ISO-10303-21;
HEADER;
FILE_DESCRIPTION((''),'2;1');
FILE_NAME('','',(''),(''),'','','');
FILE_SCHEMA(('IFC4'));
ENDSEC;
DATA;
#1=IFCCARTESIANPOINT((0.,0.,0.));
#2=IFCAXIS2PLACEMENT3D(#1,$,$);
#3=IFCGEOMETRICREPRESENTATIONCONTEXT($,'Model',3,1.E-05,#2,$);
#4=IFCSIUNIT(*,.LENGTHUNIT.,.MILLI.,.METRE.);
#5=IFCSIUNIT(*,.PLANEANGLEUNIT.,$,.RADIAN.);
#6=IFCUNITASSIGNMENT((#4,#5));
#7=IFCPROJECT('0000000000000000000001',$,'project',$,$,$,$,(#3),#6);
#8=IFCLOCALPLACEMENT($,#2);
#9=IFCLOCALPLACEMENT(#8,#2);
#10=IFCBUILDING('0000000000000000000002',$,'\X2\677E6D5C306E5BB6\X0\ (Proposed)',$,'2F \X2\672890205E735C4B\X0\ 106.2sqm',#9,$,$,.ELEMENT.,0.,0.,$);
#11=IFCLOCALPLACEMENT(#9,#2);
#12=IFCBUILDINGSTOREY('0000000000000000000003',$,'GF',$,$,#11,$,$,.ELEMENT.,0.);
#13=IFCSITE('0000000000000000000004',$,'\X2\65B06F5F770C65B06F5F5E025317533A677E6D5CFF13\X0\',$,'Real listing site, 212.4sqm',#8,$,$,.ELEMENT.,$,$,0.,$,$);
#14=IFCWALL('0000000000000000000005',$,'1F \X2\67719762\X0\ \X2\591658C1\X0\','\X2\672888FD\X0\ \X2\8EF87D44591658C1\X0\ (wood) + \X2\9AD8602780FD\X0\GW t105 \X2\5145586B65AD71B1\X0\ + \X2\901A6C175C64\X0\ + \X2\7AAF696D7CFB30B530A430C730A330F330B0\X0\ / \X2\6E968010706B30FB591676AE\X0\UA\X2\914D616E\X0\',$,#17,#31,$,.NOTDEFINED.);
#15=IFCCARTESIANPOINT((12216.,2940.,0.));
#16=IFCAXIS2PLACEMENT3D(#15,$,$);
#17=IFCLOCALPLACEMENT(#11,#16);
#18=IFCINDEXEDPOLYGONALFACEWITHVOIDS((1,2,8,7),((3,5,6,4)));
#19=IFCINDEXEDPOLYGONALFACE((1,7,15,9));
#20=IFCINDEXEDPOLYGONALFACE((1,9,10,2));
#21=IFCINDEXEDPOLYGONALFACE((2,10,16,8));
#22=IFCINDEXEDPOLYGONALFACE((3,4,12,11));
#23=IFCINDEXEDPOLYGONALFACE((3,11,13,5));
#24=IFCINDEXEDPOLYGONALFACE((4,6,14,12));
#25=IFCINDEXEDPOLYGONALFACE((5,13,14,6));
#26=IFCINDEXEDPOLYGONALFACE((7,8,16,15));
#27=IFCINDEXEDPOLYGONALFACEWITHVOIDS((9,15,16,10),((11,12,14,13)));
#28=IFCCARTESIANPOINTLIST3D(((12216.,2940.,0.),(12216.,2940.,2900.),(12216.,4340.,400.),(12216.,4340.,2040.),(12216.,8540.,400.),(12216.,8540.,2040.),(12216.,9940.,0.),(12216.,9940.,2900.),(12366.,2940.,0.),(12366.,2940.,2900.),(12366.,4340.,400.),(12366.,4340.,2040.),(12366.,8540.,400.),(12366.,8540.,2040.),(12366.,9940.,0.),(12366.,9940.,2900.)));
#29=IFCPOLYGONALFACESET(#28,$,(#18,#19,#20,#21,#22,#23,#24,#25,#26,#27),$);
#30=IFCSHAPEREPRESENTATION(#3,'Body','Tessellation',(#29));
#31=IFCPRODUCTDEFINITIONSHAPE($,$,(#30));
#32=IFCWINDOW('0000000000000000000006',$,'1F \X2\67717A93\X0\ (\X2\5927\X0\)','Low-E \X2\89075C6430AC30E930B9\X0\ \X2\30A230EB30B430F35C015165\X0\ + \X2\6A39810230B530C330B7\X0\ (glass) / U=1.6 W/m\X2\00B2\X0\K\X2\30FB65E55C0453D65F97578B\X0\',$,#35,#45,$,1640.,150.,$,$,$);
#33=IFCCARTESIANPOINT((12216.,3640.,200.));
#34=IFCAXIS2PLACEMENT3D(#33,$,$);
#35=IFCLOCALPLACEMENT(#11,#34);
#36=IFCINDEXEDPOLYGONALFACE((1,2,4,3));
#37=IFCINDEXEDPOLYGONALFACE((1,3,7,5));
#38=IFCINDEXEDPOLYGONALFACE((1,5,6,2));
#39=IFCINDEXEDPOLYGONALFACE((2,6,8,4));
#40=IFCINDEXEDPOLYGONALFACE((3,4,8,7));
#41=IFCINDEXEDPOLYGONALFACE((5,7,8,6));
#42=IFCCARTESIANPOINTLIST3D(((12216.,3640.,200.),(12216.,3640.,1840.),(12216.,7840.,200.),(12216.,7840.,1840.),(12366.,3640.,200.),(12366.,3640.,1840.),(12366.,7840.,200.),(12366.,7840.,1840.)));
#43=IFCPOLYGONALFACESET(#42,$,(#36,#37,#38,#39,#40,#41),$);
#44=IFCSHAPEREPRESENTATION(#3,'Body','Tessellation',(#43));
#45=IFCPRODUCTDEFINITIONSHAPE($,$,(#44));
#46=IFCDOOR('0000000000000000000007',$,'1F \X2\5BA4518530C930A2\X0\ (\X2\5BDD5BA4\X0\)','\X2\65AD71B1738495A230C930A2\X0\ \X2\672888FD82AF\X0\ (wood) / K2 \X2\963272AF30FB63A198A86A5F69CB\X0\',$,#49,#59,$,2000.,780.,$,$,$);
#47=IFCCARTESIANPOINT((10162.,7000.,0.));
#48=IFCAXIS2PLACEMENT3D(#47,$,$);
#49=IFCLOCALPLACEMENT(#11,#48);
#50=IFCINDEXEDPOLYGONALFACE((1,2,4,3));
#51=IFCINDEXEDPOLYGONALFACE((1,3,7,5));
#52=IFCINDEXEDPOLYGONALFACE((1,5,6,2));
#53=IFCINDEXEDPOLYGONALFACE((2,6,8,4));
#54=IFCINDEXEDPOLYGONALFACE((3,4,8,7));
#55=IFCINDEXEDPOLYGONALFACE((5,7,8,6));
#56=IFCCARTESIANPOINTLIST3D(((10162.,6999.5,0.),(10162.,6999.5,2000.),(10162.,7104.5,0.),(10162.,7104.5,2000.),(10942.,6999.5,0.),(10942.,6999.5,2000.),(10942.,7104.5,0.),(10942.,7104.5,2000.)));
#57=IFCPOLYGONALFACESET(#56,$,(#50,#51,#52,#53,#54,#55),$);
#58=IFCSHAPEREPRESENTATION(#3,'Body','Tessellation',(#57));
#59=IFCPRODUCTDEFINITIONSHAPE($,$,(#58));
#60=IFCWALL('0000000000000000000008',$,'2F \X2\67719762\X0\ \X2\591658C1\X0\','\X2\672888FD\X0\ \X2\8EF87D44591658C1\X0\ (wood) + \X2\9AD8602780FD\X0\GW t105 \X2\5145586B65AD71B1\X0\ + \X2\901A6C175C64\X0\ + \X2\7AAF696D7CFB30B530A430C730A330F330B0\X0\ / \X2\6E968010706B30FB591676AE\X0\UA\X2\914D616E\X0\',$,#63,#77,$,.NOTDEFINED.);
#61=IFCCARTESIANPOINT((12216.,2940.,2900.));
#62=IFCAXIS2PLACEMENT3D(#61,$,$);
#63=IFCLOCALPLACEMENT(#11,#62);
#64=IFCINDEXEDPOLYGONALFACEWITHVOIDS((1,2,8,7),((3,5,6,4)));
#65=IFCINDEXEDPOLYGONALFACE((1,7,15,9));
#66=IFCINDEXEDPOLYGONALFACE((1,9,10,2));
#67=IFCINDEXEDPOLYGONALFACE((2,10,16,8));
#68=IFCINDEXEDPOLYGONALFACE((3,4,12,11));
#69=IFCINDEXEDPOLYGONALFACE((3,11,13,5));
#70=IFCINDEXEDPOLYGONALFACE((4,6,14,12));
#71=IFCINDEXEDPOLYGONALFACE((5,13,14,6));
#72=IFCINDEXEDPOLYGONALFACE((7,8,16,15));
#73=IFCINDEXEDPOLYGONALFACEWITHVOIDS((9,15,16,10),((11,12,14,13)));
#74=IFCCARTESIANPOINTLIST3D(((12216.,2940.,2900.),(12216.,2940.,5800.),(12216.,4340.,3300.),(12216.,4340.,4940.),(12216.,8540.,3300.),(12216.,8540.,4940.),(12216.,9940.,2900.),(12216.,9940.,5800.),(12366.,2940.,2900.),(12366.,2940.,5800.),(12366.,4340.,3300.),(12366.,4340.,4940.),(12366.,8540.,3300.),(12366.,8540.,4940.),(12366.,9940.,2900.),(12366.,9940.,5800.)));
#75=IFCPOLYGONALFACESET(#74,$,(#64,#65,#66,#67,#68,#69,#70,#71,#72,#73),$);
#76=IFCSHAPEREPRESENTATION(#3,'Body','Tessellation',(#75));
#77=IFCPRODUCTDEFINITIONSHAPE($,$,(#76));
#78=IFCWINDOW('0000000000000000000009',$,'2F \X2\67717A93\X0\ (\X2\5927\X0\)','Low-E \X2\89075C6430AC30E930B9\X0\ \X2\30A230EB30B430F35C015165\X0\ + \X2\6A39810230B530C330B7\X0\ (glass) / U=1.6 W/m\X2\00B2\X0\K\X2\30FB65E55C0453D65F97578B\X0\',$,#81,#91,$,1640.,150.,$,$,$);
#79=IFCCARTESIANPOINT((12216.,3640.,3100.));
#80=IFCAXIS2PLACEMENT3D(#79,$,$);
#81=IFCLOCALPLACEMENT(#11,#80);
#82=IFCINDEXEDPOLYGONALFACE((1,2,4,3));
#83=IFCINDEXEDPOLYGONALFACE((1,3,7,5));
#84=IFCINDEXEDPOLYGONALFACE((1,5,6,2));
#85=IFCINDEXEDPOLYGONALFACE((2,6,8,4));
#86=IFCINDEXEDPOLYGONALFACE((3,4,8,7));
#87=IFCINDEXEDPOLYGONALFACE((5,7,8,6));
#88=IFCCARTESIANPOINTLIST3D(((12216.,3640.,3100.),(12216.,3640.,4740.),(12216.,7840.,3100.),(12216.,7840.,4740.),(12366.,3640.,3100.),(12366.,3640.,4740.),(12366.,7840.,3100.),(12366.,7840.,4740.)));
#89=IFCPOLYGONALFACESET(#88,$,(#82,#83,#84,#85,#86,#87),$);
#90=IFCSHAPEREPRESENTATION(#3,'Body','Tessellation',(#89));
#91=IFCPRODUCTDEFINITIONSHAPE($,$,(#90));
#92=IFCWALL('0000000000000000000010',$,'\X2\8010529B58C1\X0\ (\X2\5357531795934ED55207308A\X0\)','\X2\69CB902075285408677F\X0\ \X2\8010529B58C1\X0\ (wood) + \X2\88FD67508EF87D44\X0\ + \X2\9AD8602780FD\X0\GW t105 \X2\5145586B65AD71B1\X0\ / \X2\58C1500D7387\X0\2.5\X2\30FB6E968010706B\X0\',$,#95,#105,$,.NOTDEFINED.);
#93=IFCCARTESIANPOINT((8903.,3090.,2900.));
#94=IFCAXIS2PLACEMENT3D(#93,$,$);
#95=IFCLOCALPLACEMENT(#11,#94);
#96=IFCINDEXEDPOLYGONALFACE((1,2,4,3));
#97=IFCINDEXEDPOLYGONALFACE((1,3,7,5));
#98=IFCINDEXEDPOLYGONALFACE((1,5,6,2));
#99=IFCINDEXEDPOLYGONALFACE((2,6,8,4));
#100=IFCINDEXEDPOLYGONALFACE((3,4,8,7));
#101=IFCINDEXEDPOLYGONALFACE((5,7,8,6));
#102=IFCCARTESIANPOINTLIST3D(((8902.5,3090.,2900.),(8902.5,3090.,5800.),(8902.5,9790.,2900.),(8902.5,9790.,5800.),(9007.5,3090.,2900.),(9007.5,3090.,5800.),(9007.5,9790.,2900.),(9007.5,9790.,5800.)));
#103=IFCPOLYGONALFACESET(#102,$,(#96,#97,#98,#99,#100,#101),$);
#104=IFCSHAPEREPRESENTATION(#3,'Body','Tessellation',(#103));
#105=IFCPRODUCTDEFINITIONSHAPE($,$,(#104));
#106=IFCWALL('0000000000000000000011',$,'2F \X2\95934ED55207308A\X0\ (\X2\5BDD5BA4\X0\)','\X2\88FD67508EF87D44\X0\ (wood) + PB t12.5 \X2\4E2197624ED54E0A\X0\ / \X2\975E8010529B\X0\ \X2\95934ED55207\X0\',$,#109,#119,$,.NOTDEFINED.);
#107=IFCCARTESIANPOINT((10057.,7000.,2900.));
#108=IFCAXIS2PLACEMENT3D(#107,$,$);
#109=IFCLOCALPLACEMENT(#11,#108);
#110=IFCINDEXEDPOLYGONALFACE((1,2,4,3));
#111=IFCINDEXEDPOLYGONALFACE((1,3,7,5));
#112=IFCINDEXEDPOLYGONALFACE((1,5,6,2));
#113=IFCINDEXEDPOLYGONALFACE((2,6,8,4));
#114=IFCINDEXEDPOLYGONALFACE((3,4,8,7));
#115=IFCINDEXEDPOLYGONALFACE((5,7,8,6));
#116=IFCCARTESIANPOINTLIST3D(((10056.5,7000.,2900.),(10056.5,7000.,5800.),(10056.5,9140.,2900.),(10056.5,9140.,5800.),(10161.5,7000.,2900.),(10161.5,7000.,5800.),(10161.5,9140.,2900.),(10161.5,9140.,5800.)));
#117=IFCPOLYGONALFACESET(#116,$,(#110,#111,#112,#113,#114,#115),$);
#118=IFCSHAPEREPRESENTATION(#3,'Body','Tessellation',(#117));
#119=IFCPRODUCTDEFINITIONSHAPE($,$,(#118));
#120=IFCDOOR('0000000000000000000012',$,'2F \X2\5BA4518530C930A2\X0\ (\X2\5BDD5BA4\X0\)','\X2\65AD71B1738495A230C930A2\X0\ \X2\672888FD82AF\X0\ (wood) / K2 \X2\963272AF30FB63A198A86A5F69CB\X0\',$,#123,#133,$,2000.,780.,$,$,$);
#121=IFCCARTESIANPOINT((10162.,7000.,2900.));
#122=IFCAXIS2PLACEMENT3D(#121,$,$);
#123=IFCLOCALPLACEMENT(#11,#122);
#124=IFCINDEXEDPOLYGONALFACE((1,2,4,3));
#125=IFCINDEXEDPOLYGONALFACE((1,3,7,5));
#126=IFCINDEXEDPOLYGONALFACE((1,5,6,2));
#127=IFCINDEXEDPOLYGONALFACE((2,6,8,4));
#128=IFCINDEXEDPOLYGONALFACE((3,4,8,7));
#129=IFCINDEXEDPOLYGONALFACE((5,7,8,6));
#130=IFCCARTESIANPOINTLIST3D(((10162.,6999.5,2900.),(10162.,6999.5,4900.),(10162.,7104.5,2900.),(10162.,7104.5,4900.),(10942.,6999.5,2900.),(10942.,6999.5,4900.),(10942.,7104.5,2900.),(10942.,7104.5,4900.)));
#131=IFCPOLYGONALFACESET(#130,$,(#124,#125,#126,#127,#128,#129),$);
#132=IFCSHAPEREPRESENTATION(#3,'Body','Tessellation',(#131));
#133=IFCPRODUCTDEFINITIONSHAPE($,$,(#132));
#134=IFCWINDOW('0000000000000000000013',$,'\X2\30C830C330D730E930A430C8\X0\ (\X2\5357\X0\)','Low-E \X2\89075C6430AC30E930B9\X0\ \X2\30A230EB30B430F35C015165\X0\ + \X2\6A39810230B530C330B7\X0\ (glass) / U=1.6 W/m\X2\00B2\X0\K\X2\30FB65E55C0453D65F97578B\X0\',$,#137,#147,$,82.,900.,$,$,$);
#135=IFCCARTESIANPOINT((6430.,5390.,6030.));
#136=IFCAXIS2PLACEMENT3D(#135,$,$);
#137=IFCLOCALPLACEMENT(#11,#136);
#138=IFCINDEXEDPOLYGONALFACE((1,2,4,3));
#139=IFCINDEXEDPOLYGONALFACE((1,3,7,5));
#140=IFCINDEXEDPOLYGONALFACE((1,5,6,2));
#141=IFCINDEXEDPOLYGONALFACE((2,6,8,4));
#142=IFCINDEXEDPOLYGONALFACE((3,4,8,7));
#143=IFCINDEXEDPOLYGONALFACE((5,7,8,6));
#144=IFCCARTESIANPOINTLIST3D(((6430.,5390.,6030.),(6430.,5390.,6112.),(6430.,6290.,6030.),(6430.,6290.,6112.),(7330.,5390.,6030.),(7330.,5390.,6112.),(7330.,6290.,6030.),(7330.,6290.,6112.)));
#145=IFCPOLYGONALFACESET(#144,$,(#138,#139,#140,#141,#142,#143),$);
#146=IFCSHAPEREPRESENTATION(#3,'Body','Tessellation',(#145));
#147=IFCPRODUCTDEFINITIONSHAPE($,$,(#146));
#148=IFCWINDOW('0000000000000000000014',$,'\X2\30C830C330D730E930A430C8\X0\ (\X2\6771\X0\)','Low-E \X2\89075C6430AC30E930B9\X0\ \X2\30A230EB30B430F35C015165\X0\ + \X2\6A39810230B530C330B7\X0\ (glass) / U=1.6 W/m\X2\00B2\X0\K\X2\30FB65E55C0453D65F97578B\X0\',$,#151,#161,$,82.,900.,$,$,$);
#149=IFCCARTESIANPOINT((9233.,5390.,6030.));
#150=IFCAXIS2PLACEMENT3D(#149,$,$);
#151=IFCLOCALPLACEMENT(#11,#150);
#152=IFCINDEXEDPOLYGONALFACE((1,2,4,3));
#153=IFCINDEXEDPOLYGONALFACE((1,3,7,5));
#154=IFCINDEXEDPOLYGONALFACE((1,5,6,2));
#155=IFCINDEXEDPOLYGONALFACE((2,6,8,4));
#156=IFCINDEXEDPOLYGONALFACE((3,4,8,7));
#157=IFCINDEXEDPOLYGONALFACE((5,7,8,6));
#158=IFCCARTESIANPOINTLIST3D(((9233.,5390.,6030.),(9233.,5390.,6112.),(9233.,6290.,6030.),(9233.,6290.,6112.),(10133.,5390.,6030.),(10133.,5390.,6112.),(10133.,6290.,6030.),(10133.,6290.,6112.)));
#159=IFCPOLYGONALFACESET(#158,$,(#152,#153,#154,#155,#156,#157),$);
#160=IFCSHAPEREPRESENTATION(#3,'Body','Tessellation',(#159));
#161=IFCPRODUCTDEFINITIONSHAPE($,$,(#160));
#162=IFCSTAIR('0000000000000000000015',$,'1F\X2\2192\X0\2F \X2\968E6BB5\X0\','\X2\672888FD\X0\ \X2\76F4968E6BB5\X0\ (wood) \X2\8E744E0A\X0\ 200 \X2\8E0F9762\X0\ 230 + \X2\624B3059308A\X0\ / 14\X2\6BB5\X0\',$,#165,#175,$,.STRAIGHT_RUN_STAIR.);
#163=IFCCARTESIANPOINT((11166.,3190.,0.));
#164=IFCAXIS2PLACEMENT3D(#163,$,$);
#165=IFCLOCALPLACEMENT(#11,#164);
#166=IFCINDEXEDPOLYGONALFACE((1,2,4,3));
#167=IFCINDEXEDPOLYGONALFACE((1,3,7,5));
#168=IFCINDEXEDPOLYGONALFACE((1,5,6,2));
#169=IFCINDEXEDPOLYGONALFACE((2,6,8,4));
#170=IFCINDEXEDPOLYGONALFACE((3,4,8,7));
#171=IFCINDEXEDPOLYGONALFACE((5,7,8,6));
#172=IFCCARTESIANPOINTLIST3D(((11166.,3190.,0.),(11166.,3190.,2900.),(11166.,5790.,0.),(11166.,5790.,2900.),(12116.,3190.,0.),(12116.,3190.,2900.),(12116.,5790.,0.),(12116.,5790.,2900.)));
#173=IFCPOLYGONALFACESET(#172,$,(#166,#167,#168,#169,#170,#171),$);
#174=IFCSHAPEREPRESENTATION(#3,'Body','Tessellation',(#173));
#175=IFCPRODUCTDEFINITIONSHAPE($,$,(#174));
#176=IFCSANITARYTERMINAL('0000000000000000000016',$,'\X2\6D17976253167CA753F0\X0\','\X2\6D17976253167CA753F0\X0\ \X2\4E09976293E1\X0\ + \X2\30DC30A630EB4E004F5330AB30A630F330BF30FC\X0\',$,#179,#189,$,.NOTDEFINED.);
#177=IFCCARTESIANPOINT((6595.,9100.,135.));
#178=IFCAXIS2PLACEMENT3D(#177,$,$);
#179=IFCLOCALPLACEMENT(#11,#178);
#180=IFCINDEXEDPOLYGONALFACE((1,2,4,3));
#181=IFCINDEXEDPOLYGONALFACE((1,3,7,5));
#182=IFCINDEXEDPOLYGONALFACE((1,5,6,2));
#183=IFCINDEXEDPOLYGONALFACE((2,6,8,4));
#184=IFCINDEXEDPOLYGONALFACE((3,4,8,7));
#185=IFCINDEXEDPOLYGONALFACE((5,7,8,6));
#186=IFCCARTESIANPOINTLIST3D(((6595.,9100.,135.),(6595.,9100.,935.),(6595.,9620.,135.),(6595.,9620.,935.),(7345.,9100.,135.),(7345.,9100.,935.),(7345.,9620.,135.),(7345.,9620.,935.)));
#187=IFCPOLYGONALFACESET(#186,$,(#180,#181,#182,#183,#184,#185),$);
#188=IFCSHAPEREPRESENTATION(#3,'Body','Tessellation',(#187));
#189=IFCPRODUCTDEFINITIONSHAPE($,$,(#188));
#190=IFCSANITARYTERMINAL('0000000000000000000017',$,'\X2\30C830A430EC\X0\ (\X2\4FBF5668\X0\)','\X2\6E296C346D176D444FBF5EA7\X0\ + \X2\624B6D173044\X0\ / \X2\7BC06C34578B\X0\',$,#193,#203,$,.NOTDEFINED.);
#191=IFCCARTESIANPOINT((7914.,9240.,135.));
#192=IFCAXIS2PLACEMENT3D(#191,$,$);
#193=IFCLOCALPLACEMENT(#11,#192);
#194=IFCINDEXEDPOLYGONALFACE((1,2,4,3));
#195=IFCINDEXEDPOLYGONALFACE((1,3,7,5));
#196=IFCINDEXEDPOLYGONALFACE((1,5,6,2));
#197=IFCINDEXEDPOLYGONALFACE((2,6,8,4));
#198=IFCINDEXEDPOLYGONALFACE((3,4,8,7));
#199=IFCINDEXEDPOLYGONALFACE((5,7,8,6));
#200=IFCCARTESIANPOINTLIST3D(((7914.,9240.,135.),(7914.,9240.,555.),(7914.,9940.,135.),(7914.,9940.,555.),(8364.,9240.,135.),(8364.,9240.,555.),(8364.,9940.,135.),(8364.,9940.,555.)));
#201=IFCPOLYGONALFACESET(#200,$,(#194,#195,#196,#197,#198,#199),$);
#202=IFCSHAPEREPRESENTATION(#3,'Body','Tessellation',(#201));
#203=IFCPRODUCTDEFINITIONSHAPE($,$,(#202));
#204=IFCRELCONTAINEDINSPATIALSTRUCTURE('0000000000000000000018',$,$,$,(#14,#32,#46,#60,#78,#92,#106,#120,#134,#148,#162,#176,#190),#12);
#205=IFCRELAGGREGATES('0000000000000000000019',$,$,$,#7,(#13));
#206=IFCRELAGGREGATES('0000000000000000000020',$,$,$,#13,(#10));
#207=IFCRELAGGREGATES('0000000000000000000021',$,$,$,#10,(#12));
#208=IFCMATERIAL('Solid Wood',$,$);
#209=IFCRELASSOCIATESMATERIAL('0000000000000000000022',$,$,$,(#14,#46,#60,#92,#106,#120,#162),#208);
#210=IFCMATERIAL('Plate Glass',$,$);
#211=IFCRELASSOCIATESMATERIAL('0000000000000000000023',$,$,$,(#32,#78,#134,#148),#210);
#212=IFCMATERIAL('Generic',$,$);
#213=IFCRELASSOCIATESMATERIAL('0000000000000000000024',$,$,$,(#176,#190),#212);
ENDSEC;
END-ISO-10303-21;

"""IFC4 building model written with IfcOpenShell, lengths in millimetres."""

from ifc_helpers import new_model, si_unit, frame, frame_2d, origin, place, context, project, spatial, rectangle, extrude, material, element, fill, save


model = new_model("IFC4")

# Units and contexts
model_context = context("Model", 3, precision=1e-05, world=origin())
ifc_project = project(units=[si_unit("LENGTHUNIT", "METRE", prefix="MILLI"), si_unit("PLANEANGLEUNIT", "RADIAN")], contexts=[model_context])

# Site, building, storey
site_placement = place(None, origin())
site = spatial("IfcSite", under=ifc_project, at=site_placement, Name="新潟県新潟市北区松浜３", ObjectType="Real listing site, 212.4sqm", CompositionType="ELEMENT", RefElevation=0.0)
building_placement = place(site_placement, origin())
building = spatial("IfcBuilding", under=site, at=building_placement, Name="松浜の家 (Proposed)", ObjectType="2F 木造平屋 106.2sqm", CompositionType="ELEMENT", ElevationOfRefHeight=0.0, ElevationOfTerrain=0.0)
storey_placement = place(building_placement, origin())
storey = spatial("IfcBuildingStorey", under=building, at=storey_placement, Name="GF", CompositionType="ELEMENT", Elevation=0.0)

# Wall, opening, window
ifc_material_1 = material(Name="Solid Wood")
wall_1_placement = place(storey_placement, frame((12216.0, 2940.0, 0.0)))
wall_1 = element("IfcWall", 1, at=wall_1_placement, inside=storey, material=ifc_material_1, Name="1F 東面 外壁", Description="木製 軸組外壁 (wood) + 高性能GW t105 充填断熱 + 通気層 + 窯業系サイディング / 準耐火・外皮UA配慮", PredefinedType="NOTDEFINED", context=model_context, shape_type="SweptSolid", body=[
    extrude(rectangle(XDim=150.0, YDim=7000.0, at=frame_2d((75.0, 3500.0))), frame((12216.0, 2940.0, 0.0)), (0.0, 0.0, 1.0), 2900.0),
])
opening_1_placement = place(storey_placement, frame((12216.0, 3640.0, 200.0)))
opening_1 = element("IfcOpeningElement", 2, at=opening_1_placement, cuts=wall_1, PredefinedType="NOTDEFINED", context=model_context, shape_type="SweptSolid", body=[
    extrude(rectangle(XDim=150.0, YDim=4200.0, at=frame_2d((75.0, 2100.0))), frame((12216.0, 3640.0, 200.0)), (0.0, 0.0, 1.0), 1640.0),
])
ifc_material_2 = material(Name="Plate Glass")
window_1_placement = place(storey_placement, frame((12216.0, 3640.0, 200.0)))
window_1 = element("IfcWindow", 3, at=window_1_placement, inside=storey, material=ifc_material_2, Name="1F 東窓 (大)", Description="Low-E 複層ガラス アルゴン封入 + 樹脂サッシ (glass) / U=1.6 W/m²K・日射取得型", OverallHeight=1640.0, OverallWidth=150.0, context=model_context, shape_type="SweptSolid", body=[
    extrude(rectangle(XDim=150.0, YDim=4200.0, at=frame_2d((75.0, 2100.0))), frame((12216.0, 3640.0, 200.0)), (0.0, 0.0, 1.0), 1640.0),
])
fill(opening_1, window_1)

# Door
door_1_placement = place(storey_placement, frame((10162.0, 7000.0, 0.0)))
element("IfcDoor", 4, at=door_1_placement, inside=storey, material=ifc_material_1, Name="1F 室内ドア (寝室)", Description="断熱玄関ドア 木製芯 (wood) / K2 防犯・採風機構", OverallHeight=2000.0, OverallWidth=780.0, context=model_context, shape_type="SweptSolid", body=[
    extrude(rectangle(XDim=780.0, YDim=105.0, at=frame_2d((390.0, 52.0))), frame((10162.0, 7000.0, 0.0)), (0.0, 0.0, 1.0), 2000.0),
])

# Wall, opening, window
wall_2_placement = place(storey_placement, frame((12216.0, 2940.0, 2900.0)))
wall_2 = element("IfcWall", 5, at=wall_2_placement, inside=storey, material=ifc_material_1, Name="2F 東面 外壁", Description="木製 軸組外壁 (wood) + 高性能GW t105 充填断熱 + 通気層 + 窯業系サイディング / 準耐火・外皮UA配慮", PredefinedType="NOTDEFINED", context=model_context, shape_type="SweptSolid", body=[
    extrude(rectangle(XDim=150.0, YDim=7000.0, at=frame_2d((75.0, 3500.0))), frame((12216.0, 2940.0, 2900.0)), (0.0, 0.0, 1.0), 2900.0),
])
opening_2_placement = place(storey_placement, frame((12216.0, 3640.0, 3100.0)))
opening_2 = element("IfcOpeningElement", 6, at=opening_2_placement, cuts=wall_2, PredefinedType="NOTDEFINED", context=model_context, shape_type="SweptSolid", body=[
    extrude(rectangle(XDim=150.0, YDim=4200.0, at=frame_2d((75.0, 2100.0))), frame((12216.0, 3640.0, 3100.0)), (0.0, 0.0, 1.0), 1640.0),
])
window_2_placement = place(storey_placement, frame((12216.0, 3640.0, 3100.0)))
window_2 = element("IfcWindow", 7, at=window_2_placement, inside=storey, material=ifc_material_2, Name="2F 東窓 (大)", Description="Low-E 複層ガラス アルゴン封入 + 樹脂サッシ (glass) / U=1.6 W/m²K・日射取得型", OverallHeight=1640.0, OverallWidth=150.0, context=model_context, shape_type="SweptSolid", body=[
    extrude(rectangle(XDim=150.0, YDim=4200.0, at=frame_2d((75.0, 2100.0))), frame((12216.0, 3640.0, 3100.0)), (0.0, 0.0, 1.0), 1640.0),
])
fill(opening_2, window_2)

# Walls
wall_3_placement = place(storey_placement, frame((8903.0, 3090.0, 2900.0)))
element("IfcWall", 8, at=wall_3_placement, inside=storey, material=ifc_material_1, Name="耐力壁 (南北間仕切り)", Description="構造用合板 耐力壁 (wood) + 製材軸組 + 高性能GW t105 充填断熱 / 壁倍率2.5・準耐火", PredefinedType="NOTDEFINED", context=model_context, shape_type="SweptSolid", body=[
    extrude(rectangle(XDim=105.0, YDim=6700.0, at=frame_2d((52.0, 3350.0))), frame((8903.0, 3090.0, 2900.0)), (0.0, 0.0, 1.0), 2900.0),
])
wall_4_placement = place(storey_placement, frame((10057.0, 7000.0, 2900.0)))
element("IfcWall", 9, at=wall_4_placement, inside=storey, material=ifc_material_1, Name="2F 間仕切り (寝室)", Description="製材軸組 (wood) + PB t12.5 両面仕上 / 非耐力 間仕切", PredefinedType="NOTDEFINED", context=model_context, shape_type="SweptSolid", body=[
    extrude(rectangle(XDim=105.0, YDim=2140.0, at=frame_2d((52.0, 1070.0))), frame((10057.0, 7000.0, 2900.0)), (0.0, 0.0, 1.0), 2900.0),
])

# Door
door_2_placement = place(storey_placement, frame((10162.0, 7000.0, 2900.0)))
element("IfcDoor", 10, at=door_2_placement, inside=storey, material=ifc_material_1, Name="2F 室内ドア (寝室)", Description="断熱玄関ドア 木製芯 (wood) / K2 防犯・採風機構", OverallHeight=2000.0, OverallWidth=780.0, context=model_context, shape_type="SweptSolid", body=[
    extrude(rectangle(XDim=780.0, YDim=105.0, at=frame_2d((390.0, 52.0))), frame((10162.0, 7000.0, 2900.0)), (0.0, 0.0, 1.0), 2000.0),
])

# Windows
window_3_placement = place(storey_placement, frame((6430.0, 5390.0, 6030.0)))
element("IfcWindow", 11, at=window_3_placement, inside=storey, material=ifc_material_2, Name="トップライト (南)", Description="Low-E 複層ガラス アルゴン封入 + 樹脂サッシ (glass) / U=1.6 W/m²K・日射取得型", OverallHeight=82.0, OverallWidth=900.0, context=model_context, shape_type="SweptSolid", body=[
    extrude(rectangle(XDim=900.0, YDim=900.0, at=frame_2d((450.0, 450.0))), frame((6430.0, 5390.0, 6030.0)), (0.0, 0.0, 1.0), 82.0),
])
window_4_placement = place(storey_placement, frame((9233.0, 5390.0, 6030.0)))
element("IfcWindow", 12, at=window_4_placement, inside=storey, material=ifc_material_2, Name="トップライト (東)", Description="Low-E 複層ガラス アルゴン封入 + 樹脂サッシ (glass) / U=1.6 W/m²K・日射取得型", OverallHeight=82.0, OverallWidth=900.0, context=model_context, shape_type="SweptSolid", body=[
    extrude(rectangle(XDim=900.0, YDim=900.0, at=frame_2d((450.0, 450.0))), frame((9233.0, 5390.0, 6030.0)), (0.0, 0.0, 1.0), 82.0),
])

# Stair
stair_placement = place(storey_placement, frame((11166.0, 3190.0, 0.0)))
element("IfcStair", 13, at=stair_placement, inside=storey, material=ifc_material_1, Name="1F→2F 階段", Description="木製 直階段 (wood) 蹴上 200 踏面 230 + 手すり / 14段", PredefinedType="STRAIGHT_RUN_STAIR", context=model_context, shape_type="SweptSolid", body=[
    extrude(rectangle(XDim=950.0, YDim=2600.0, at=frame_2d((475.0, 1300.0))), frame((11166.0, 3190.0, 0.0)), (0.0, 0.0, 1.0), 2900.0),
])

# Sanitary terminals
ifc_material_3 = material(Name="Generic")
sanitary_terminal_1_placement = place(storey_placement, frame((6595.0, 9100.0, 135.0)))
element("IfcSanitaryTerminal", 14, at=sanitary_terminal_1_placement, inside=storey, material=ifc_material_3, Name="洗面化粧台", Description="洗面化粧台 三面鏡 + ボウル一体カウンター", PredefinedType="NOTDEFINED", context=model_context, shape_type="SweptSolid", body=[
    extrude(rectangle(XDim=750.0, YDim=520.0, at=frame_2d((375.0, 260.0))), frame((6595.0, 9100.0, 135.0)), (0.0, 0.0, 1.0), 800.0),
])
sanitary_terminal_2_placement = place(storey_placement, frame((7914.0, 9240.0, 135.0)))
element("IfcSanitaryTerminal", 15, at=sanitary_terminal_2_placement, inside=storey, material=ifc_material_3, Name="トイレ (便器)", Description="温水洗浄便座 + 手洗い / 節水型", PredefinedType="NOTDEFINED", context=model_context, shape_type="SweptSolid", body=[
    extrude(rectangle(XDim=450.0, YDim=700.0, at=frame_2d((225.0, 350.0))), frame((7914.0, 9240.0, 135.0)), (0.0, 0.0, 1.0), 420.0),
])

save(model, "model.ifc")
